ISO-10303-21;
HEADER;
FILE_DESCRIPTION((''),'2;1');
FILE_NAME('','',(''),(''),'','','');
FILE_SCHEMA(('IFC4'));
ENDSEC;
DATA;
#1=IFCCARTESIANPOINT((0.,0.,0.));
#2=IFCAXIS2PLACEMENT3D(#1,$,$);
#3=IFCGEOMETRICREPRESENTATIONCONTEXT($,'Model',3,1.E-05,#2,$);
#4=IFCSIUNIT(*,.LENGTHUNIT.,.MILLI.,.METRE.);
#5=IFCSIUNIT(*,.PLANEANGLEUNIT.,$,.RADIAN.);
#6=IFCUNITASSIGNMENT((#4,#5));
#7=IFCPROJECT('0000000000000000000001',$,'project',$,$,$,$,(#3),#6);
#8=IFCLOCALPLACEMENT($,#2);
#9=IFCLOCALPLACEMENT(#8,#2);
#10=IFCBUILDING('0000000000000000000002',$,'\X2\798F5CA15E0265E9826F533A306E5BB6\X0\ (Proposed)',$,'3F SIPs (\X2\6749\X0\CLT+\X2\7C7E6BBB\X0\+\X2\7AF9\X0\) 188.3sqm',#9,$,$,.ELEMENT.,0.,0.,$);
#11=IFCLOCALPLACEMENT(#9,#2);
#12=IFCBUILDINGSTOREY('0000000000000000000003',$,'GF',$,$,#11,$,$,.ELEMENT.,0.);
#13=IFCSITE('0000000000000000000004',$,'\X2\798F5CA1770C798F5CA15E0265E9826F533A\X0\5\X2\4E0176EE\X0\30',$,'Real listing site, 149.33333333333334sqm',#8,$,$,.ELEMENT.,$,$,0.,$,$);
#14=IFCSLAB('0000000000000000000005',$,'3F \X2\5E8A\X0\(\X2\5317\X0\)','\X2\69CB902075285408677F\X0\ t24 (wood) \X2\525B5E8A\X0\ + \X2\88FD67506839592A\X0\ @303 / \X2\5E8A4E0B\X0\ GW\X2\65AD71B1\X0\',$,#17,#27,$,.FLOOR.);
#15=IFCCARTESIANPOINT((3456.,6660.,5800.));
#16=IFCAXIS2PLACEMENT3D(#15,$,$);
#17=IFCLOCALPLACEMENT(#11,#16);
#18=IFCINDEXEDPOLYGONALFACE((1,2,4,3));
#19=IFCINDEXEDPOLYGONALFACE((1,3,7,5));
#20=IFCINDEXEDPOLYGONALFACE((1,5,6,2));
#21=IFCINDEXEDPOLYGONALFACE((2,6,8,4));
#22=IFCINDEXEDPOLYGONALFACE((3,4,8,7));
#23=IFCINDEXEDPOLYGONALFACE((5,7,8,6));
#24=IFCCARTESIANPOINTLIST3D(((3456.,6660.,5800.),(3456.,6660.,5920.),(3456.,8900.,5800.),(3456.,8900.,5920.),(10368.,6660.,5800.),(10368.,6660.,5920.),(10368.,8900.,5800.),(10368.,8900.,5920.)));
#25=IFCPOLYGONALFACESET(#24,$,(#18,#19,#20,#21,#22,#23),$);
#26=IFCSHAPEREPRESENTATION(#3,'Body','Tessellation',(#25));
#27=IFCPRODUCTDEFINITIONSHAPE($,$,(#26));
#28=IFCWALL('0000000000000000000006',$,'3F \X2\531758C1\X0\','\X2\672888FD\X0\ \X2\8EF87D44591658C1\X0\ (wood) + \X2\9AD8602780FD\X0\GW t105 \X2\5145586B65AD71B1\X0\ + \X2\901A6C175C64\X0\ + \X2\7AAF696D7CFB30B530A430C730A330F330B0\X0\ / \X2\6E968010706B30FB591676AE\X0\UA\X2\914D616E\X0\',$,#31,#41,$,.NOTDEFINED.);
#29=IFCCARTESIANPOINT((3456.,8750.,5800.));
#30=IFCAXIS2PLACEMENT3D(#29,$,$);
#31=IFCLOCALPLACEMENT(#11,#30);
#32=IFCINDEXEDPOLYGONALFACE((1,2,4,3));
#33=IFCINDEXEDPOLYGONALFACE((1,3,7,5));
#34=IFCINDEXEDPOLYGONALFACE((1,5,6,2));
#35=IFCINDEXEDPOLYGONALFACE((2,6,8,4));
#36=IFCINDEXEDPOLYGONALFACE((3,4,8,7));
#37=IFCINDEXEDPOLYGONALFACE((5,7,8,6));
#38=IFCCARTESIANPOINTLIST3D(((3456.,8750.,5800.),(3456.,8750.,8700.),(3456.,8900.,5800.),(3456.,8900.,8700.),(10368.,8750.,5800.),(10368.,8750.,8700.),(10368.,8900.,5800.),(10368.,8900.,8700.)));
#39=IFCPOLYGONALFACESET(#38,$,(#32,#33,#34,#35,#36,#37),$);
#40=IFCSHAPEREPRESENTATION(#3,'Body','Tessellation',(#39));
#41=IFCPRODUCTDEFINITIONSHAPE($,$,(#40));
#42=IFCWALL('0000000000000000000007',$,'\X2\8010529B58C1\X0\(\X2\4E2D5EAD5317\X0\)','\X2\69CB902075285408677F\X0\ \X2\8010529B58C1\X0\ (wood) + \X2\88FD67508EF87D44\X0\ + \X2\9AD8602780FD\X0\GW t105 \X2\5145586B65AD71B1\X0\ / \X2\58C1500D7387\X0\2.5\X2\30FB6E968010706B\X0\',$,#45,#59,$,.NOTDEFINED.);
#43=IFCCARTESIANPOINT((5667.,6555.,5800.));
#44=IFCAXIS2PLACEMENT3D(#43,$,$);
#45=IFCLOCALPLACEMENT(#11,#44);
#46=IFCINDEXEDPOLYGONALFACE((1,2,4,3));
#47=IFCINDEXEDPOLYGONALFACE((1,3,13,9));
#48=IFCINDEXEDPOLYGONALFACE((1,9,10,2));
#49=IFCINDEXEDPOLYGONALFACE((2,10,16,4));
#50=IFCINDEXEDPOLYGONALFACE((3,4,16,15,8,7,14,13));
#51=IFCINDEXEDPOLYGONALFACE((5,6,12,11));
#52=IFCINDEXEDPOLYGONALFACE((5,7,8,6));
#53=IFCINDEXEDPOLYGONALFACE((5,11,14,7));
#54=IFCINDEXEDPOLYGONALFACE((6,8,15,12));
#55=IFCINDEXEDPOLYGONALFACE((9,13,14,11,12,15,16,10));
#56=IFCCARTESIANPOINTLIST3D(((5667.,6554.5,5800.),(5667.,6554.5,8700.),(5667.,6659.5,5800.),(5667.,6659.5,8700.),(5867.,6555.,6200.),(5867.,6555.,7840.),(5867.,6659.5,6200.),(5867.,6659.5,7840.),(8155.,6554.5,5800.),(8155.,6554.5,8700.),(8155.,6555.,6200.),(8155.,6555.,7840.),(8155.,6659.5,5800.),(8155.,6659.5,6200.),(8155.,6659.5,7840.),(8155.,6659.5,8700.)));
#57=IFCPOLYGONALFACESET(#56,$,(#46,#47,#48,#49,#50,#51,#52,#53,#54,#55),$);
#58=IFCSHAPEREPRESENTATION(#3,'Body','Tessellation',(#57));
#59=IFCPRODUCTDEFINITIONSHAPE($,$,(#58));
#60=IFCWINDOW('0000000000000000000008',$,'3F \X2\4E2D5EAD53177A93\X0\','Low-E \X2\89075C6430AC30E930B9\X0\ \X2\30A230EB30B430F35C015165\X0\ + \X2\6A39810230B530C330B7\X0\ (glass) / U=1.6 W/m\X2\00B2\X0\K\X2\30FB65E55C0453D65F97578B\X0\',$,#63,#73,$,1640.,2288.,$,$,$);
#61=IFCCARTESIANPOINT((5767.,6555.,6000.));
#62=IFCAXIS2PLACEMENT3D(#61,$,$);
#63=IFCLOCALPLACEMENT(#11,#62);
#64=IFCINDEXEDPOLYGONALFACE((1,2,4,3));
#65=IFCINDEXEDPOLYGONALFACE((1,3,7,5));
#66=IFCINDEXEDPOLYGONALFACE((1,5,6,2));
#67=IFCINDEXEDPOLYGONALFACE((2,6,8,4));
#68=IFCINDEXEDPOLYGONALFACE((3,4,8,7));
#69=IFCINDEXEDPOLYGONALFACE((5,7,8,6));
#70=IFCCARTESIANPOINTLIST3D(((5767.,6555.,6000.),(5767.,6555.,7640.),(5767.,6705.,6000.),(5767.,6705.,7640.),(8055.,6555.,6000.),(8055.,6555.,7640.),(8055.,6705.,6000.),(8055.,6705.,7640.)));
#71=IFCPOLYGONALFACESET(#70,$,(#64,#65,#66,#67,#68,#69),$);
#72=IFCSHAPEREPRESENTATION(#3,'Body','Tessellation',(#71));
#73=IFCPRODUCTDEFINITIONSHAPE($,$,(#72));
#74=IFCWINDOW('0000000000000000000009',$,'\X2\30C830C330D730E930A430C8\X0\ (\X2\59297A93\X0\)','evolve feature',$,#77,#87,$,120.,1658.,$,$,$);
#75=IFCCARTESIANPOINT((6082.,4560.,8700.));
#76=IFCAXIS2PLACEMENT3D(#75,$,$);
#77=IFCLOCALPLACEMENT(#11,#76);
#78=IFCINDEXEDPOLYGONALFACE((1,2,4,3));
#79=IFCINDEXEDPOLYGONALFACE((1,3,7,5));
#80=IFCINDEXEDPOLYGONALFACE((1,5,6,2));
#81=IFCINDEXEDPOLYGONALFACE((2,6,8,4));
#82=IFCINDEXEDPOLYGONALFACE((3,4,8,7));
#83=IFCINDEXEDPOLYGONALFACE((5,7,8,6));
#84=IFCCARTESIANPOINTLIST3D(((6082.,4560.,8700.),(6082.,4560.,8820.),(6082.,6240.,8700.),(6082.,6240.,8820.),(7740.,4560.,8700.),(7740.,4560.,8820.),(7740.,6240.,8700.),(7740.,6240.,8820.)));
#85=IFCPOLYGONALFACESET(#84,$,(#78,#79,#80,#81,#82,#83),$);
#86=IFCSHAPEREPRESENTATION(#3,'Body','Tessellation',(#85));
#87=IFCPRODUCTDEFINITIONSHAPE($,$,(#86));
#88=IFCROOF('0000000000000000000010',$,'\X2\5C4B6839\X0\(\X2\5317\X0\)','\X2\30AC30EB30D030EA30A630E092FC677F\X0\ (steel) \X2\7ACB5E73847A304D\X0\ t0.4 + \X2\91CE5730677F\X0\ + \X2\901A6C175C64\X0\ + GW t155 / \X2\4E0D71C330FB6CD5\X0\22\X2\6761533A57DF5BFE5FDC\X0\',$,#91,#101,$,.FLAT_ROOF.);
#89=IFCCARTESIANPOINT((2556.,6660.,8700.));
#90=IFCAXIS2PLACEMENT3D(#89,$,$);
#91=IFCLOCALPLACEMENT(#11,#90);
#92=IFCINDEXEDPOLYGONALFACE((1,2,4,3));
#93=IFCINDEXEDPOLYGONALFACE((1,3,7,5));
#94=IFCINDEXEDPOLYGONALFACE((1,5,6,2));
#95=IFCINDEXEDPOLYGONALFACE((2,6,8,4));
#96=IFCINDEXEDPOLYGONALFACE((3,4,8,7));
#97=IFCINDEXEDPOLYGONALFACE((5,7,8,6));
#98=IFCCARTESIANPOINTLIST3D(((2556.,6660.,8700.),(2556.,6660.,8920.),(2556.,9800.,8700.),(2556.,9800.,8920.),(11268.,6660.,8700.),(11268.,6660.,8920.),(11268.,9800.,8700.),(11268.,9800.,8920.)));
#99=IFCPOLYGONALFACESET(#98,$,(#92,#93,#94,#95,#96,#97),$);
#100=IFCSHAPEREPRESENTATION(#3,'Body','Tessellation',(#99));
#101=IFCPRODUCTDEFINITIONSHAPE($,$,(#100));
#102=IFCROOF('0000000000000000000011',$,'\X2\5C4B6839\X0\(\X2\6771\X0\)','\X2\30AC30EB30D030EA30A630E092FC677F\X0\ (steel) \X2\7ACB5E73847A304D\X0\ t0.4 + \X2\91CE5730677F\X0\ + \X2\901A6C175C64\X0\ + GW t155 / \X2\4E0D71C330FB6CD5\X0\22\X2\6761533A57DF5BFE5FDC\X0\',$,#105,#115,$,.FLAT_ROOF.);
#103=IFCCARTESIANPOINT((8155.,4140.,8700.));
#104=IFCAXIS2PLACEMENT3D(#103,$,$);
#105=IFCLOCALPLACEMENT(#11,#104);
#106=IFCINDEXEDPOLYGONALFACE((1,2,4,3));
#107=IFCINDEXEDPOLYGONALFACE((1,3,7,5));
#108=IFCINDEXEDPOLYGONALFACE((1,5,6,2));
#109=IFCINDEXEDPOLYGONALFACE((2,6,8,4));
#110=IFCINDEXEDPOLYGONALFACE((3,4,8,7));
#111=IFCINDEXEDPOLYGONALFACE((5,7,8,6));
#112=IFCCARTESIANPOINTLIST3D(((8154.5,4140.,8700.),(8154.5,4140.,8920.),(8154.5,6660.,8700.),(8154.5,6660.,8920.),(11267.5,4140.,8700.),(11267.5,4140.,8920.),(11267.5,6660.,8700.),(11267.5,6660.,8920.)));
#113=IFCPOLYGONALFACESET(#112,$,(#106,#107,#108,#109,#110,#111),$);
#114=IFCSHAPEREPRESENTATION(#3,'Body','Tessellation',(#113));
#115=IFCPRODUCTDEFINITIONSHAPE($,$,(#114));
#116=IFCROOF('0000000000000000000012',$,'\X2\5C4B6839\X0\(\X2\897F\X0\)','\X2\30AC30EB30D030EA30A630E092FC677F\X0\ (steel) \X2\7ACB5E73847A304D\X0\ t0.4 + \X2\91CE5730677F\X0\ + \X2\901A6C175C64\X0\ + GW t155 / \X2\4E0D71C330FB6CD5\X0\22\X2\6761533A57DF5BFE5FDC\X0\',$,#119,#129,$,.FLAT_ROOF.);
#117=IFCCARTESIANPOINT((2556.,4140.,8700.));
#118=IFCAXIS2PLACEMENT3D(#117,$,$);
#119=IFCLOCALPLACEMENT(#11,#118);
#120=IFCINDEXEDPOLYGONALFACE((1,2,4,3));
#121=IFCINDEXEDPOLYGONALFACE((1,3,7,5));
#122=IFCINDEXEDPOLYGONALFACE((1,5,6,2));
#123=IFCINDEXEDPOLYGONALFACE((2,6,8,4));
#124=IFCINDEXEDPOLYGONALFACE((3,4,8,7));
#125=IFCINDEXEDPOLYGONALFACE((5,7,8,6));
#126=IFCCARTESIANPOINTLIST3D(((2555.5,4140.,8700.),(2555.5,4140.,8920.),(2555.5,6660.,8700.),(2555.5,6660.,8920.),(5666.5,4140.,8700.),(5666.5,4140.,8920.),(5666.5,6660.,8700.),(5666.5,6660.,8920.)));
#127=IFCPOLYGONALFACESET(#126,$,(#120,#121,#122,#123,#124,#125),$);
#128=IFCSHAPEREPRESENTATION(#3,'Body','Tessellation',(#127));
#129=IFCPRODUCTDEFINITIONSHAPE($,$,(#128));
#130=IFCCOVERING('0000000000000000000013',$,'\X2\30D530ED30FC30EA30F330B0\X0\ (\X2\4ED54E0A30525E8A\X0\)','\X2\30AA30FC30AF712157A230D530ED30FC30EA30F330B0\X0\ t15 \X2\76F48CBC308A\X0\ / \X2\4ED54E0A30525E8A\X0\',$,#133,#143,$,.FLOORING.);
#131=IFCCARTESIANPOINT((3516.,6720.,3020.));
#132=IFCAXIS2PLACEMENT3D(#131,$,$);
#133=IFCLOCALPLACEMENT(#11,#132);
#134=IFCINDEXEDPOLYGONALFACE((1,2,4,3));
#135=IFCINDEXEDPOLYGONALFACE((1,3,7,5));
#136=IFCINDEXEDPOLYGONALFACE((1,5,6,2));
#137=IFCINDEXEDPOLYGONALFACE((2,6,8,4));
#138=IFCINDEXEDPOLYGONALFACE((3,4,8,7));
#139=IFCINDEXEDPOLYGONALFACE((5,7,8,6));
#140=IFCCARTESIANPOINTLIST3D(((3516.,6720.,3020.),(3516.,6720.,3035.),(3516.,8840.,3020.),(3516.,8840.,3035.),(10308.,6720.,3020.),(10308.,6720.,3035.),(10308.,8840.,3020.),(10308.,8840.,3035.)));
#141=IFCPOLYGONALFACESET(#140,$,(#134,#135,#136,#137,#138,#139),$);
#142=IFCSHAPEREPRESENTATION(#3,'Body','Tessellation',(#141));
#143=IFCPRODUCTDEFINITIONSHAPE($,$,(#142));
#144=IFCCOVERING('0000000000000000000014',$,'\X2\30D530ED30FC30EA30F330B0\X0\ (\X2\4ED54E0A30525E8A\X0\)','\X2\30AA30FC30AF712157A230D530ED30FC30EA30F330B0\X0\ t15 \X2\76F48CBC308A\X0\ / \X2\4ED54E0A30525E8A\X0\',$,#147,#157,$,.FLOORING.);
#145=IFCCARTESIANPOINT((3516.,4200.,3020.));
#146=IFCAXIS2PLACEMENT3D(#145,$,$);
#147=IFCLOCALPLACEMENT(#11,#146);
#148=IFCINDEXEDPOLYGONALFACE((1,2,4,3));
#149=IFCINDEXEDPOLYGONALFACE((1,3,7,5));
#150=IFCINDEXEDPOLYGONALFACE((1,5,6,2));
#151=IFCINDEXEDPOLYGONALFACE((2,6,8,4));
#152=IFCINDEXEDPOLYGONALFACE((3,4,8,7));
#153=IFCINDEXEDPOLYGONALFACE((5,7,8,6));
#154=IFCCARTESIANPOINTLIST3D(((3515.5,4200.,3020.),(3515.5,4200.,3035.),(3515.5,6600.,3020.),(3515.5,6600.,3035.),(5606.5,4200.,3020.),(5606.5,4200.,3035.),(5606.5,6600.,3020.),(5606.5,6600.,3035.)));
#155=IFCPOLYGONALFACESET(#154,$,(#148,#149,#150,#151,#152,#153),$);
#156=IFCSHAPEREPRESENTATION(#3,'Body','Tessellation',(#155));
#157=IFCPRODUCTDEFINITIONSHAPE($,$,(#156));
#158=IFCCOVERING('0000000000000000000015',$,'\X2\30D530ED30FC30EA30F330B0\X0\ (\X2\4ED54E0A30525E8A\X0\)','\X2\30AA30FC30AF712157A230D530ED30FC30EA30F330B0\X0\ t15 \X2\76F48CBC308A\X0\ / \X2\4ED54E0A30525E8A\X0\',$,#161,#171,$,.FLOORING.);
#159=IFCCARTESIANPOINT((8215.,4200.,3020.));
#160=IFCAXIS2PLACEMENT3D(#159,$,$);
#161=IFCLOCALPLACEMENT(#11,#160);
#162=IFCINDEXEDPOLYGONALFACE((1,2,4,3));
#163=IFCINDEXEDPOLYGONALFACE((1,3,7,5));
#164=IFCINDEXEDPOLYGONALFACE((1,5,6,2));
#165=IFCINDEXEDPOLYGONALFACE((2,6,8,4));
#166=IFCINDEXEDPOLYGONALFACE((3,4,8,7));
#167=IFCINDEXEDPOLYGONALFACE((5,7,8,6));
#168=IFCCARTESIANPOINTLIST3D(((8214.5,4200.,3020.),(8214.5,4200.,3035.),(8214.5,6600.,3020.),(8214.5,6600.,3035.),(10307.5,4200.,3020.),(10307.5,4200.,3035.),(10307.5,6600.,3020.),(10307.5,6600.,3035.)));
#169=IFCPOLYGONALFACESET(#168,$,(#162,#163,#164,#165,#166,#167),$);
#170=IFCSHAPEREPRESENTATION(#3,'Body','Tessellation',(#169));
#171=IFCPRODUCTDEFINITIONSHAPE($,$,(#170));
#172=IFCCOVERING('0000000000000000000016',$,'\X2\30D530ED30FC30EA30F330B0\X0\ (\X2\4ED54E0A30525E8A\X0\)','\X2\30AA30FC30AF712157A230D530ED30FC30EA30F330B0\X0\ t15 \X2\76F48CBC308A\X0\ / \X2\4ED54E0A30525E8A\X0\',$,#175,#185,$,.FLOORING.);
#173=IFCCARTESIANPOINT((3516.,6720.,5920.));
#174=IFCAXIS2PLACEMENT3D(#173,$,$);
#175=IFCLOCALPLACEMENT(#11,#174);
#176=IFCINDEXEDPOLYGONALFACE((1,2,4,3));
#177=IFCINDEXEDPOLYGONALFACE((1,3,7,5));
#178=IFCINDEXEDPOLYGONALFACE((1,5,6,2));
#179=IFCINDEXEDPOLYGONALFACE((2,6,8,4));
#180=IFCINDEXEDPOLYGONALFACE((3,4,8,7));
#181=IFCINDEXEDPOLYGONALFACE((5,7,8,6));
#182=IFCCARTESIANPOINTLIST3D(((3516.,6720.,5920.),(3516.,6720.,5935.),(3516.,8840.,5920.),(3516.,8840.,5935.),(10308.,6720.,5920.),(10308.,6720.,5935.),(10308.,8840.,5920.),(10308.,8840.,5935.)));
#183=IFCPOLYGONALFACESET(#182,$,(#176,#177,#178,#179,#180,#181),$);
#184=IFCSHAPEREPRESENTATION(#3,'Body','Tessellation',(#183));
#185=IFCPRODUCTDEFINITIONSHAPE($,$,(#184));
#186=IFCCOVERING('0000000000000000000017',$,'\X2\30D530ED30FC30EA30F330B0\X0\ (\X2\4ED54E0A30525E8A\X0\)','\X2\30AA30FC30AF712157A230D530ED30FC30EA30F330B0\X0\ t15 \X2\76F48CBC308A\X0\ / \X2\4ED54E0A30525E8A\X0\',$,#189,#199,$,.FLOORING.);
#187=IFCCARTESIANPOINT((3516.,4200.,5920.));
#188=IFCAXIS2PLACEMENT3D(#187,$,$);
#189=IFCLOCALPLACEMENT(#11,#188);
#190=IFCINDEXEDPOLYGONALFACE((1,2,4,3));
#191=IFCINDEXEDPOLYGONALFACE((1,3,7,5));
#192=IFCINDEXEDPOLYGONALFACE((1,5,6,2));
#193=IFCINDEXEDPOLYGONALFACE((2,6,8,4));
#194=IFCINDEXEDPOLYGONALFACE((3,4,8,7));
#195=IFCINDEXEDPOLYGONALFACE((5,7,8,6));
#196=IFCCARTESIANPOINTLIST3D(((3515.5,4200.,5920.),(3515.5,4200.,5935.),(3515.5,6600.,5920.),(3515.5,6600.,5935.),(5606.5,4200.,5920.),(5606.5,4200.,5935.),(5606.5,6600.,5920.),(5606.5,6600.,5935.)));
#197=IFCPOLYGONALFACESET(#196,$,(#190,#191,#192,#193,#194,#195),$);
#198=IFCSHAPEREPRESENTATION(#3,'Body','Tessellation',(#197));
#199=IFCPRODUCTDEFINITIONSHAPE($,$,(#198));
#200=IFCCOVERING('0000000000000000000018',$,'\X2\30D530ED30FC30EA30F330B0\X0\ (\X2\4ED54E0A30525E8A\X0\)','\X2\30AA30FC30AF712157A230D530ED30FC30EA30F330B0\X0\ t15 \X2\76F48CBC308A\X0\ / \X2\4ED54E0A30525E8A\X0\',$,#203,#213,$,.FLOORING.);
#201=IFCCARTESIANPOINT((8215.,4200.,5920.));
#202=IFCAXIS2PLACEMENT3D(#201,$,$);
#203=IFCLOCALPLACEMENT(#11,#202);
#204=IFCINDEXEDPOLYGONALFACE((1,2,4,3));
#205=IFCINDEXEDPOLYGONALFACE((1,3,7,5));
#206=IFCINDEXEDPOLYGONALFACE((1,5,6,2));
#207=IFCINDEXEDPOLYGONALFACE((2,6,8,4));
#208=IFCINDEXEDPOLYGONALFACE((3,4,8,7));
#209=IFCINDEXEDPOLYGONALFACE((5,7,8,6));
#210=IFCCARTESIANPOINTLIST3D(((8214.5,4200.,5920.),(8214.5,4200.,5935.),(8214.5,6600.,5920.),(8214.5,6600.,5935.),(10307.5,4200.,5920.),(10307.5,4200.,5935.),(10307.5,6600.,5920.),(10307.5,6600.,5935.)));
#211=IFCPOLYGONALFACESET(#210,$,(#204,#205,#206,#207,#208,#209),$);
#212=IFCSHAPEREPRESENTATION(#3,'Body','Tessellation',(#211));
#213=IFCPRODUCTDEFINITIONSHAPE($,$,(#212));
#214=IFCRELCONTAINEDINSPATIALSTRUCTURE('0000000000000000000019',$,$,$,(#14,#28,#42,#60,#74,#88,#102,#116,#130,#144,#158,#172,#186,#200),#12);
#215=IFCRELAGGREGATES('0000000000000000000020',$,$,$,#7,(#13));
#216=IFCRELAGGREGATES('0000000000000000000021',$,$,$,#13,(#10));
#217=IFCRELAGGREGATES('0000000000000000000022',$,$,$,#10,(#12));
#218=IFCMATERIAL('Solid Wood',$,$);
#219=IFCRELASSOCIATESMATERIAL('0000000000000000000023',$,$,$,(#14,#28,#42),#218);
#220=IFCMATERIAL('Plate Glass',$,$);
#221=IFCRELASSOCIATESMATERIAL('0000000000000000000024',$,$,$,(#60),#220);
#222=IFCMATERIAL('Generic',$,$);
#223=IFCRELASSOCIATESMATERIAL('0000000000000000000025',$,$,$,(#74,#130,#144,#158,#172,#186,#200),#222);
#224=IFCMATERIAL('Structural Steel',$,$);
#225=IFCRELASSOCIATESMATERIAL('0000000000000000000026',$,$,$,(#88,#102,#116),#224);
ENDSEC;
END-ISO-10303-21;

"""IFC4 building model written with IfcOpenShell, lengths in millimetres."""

from ifc_helpers import new_model, si_unit, frame, frame_2d, origin, place, context, project, spatial, rectangle, extrude, material, element, fill, save


model = new_model("IFC4")

# Units and contexts
model_context = context("Model", 3, precision=1e-05, world=origin())
ifc_project = project(units=[si_unit("LENGTHUNIT", "METRE", prefix="MILLI"), si_unit("PLANEANGLEUNIT", "RADIAN")], contexts=[model_context])

# Site, building, storey
site_placement = place(None, origin())
site = spatial("IfcSite", under=ifc_project, at=site_placement, Name="福岡県福岡市早良区5丁目30", ObjectType="Real listing site, 149.33333333333334sqm", CompositionType="ELEMENT", RefElevation=0.0)
building_placement = place(site_placement, origin())
building = spatial("IfcBuilding", under=site, at=building_placement, Name="福岡市早良区の家 (Proposed)", ObjectType="3F SIPs (杉CLT+籾殻+竹) 188.3sqm", CompositionType="ELEMENT", ElevationOfRefHeight=0.0, ElevationOfTerrain=0.0)
storey_placement = place(building_placement, origin())
storey = spatial("IfcBuildingStorey", under=building, at=storey_placement, Name="GF", CompositionType="ELEMENT", Elevation=0.0)

# Slab
ifc_material_1 = material(Name="Solid Wood")
slab_placement = place(storey_placement, frame((3456.0, 6660.0, 5800.0)))
element("IfcSlab", 1, at=slab_placement, inside=storey, material=ifc_material_1, Name="3F 床(北)", Description="構造用合板 t24 (wood) 剛床 + 製材根太 @303 / 床下 GW断熱", PredefinedType="FLOOR", context=model_context, shape_type="SweptSolid", body=[
    extrude(rectangle(XDim=6912.0, YDim=2240.0, at=frame_2d((3456.0, 1120.0))), frame((3456.0, 6660.0, 5800.0)), (0.0, 0.0, 1.0), 120.0),
])

# Wall
wall_1_placement = place(storey_placement, frame((3456.0, 8750.0, 5800.0)))
element("IfcWall", 2, at=wall_1_placement, inside=storey, material=ifc_material_1, Name="3F 北壁", Description="木製 軸組外壁 (wood) + 高性能GW t105 充填断熱 + 通気層 + 窯業系サイディング / 準耐火・外皮UA配慮", PredefinedType="NOTDEFINED", context=model_context, shape_type="SweptSolid", body=[
    extrude(rectangle(XDim=6912.0, YDim=150.0, at=frame_2d((3456.0, 75.0))), frame((3456.0, 8750.0, 5800.0)), (0.0, 0.0, 1.0), 2900.0),
])

# Wall, opening, window
wall_2_placement = place(storey_placement, frame((5667.0, 6555.0, 5800.0)))
wall_2 = element("IfcWall", 3, at=wall_2_placement, inside=storey, material=ifc_material_1, Name="耐力壁(中庭北)", Description="構造用合板 耐力壁 (wood) + 製材軸組 + 高性能GW t105 充填断熱 / 壁倍率2.5・準耐火", PredefinedType="NOTDEFINED", context=model_context, shape_type="SweptSolid", body=[
    extrude(rectangle(XDim=2488.0, YDim=105.0, at=frame_2d((1244.0, 52.0))), frame((5667.0, 6555.0, 5800.0)), (0.0, 0.0, 1.0), 2900.0),
])
opening_placement = place(storey_placement, frame((5767.0, 6555.0, 6000.0)))
opening = element("IfcOpeningElement", 4, at=opening_placement, cuts=wall_2, PredefinedType="NOTDEFINED", context=model_context, shape_type="SweptSolid", body=[
    extrude(rectangle(XDim=2288.0, YDim=150.0, at=frame_2d((1144.0, 75.0))), frame((5767.0, 6555.0, 6000.0)), (0.0, 0.0, 1.0), 1640.0),
])
ifc_material_2 = material(Name="Plate Glass")
window_1_placement = place(storey_placement, frame((5767.0, 6555.0, 6000.0)))
window_1 = element("IfcWindow", 5, at=window_1_placement, inside=storey, material=ifc_material_2, Name="3F 中庭北窓", Description="Low-E 複層ガラス アルゴン封入 + 樹脂サッシ (glass) / U=1.6 W/m²K・日射取得型", OverallHeight=1640.0, OverallWidth=2288.0, context=model_context, shape_type="SweptSolid", body=[
    extrude(rectangle(XDim=2288.0, YDim=150.0, at=frame_2d((1144.0, 75.0))), frame((5767.0, 6555.0, 6000.0)), (0.0, 0.0, 1.0), 1640.0),
])
fill(opening, window_1)

# Window
ifc_material_3 = material(Name="Generic")
window_2_placement = place(storey_placement, frame((6082.0, 4560.0, 8700.0)))
element("IfcWindow", 6, at=window_2_placement, inside=storey, material=ifc_material_3, Name="トップライト (天窓)", Description="evolve feature", OverallHeight=120.0, OverallWidth=1658.0, context=model_context, shape_type="SweptSolid", body=[
    extrude(rectangle(XDim=1658.0, YDim=1680.0, at=frame_2d((829.0, 840.0))), frame((6082.0, 4560.0, 8700.0)), (0.0, 0.0, 1.0), 120.0),
])

# Roofs
ifc_material_4 = material(Name="Structural Steel")
roof_1_placement = place(storey_placement, frame((2556.0, 6660.0, 8700.0)))
element("IfcRoof", 7, at=roof_1_placement, inside=storey, material=ifc_material_4, Name="屋根(北)", Description="ガルバリウム鋼板 (steel) 立平葺き t0.4 + 野地板 + 通気層 + GW t155 / 不燃・法22条区域対応", PredefinedType="FLAT_ROOF", context=model_context, shape_type="SweptSolid", body=[
    extrude(rectangle(XDim=8712.0, YDim=3140.0, at=frame_2d((4356.0, 1570.0))), frame((2556.0, 6660.0, 8700.0)), (0.0, 0.0, 1.0), 220.0),
])
roof_2_placement = place(storey_placement, frame((8155.0, 4140.0, 8700.0)))
element("IfcRoof", 8, at=roof_2_placement, inside=storey, material=ifc_material_4, Name="屋根(東)", Description="ガルバリウム鋼板 (steel) 立平葺き t0.4 + 野地板 + 通気層 + GW t155 / 不燃・法22条区域対応", PredefinedType="FLAT_ROOF", context=model_context, shape_type="SweptSolid", body=[
    extrude(rectangle(XDim=3113.0, YDim=2520.0, at=frame_2d((1556.0, 1260.0))), frame((8155.0, 4140.0, 8700.0)), (0.0, 0.0, 1.0), 220.0),
])
roof_3_placement = place(storey_placement, frame((2556.0, 4140.0, 8700.0)))
element("IfcRoof", 9, at=roof_3_placement, inside=storey, material=ifc_material_4, Name="屋根(西)", Description="ガルバリウム鋼板 (steel) 立平葺き t0.4 + 野地板 + 通気層 + GW t155 / 不燃・法22条区域対応", PredefinedType="FLAT_ROOF", context=model_context, shape_type="SweptSolid", body=[
    extrude(rectangle(XDim=3111.0, YDim=2520.0, at=frame_2d((1555.0, 1260.0))), frame((2556.0, 4140.0, 8700.0)), (0.0, 0.0, 1.0), 220.0),
])

# Coverings
covering_1_placement = place(storey_placement, frame((3516.0, 6720.0, 3020.0)))
element("IfcCovering", 10, at=covering_1_placement, inside=storey, material=ifc_material_3, Name="フローリング (仕上げ床)", Description="オーク無垢フローリング t15 直貼り / 仕上げ床", PredefinedType="FLOORING", context=model_context, shape_type="SweptSolid", body=[
    extrude(rectangle(XDim=6792.0, YDim=2120.0, at=frame_2d((3396.0, 1060.0))), frame((3516.0, 6720.0, 3020.0)), (0.0, 0.0, 1.0), 15.0),
])
covering_2_placement = place(storey_placement, frame((3516.0, 4200.0, 3020.0)))
element("IfcCovering", 11, at=covering_2_placement, inside=storey, material=ifc_material_3, Name="フローリング (仕上げ床)", Description="オーク無垢フローリング t15 直貼り / 仕上げ床", PredefinedType="FLOORING", context=model_context, shape_type="SweptSolid", body=[
    extrude(rectangle(XDim=2091.0, YDim=2400.0, at=frame_2d((1045.0, 1200.0))), frame((3516.0, 4200.0, 3020.0)), (0.0, 0.0, 1.0), 15.0),
])
covering_3_placement = place(storey_placement, frame((8215.0, 4200.0, 3020.0)))
element("IfcCovering", 12, at=covering_3_placement, inside=storey, material=ifc_material_3, Name="フローリング (仕上げ床)", Description="オーク無垢フローリング t15 直貼り / 仕上げ床", PredefinedType="FLOORING", context=model_context, shape_type="SweptSolid", body=[
    extrude(rectangle(XDim=2093.0, YDim=2400.0, at=frame_2d((1046.0, 1200.0))), frame((8215.0, 4200.0, 3020.0)), (0.0, 0.0, 1.0), 15.0),
])
covering_4_placement = place(storey_placement, frame((3516.0, 6720.0, 5920.0)))
element("IfcCovering", 13, at=covering_4_placement, inside=storey, material=ifc_material_3, Name="フローリング (仕上げ床)", Description="オーク無垢フローリング t15 直貼り / 仕上げ床", PredefinedType="FLOORING", context=model_context, shape_type="SweptSolid", body=[
    extrude(rectangle(XDim=6792.0, YDim=2120.0, at=frame_2d((3396.0, 1060.0))), frame((3516.0, 6720.0, 5920.0)), (0.0, 0.0, 1.0), 15.0),
])
covering_5_placement = place(storey_placement, frame((3516.0, 4200.0, 5920.0)))
element("IfcCovering", 14, at=covering_5_placement, inside=storey, material=ifc_material_3, Name="フローリング (仕上げ床)", Description="オーク無垢フローリング t15 直貼り / 仕上げ床", PredefinedType="FLOORING", context=model_context, shape_type="SweptSolid", body=[
    extrude(rectangle(XDim=2091.0, YDim=2400.0, at=frame_2d((1045.0, 1200.0))), frame((3516.0, 4200.0, 5920.0)), (0.0, 0.0, 1.0), 15.0),
])
covering_6_placement = place(storey_placement, frame((8215.0, 4200.0, 5920.0)))
element("IfcCovering", 15, at=covering_6_placement, inside=storey, material=ifc_material_3, Name="フローリング (仕上げ床)", Description="オーク無垢フローリング t15 直貼り / 仕上げ床", PredefinedType="FLOORING", context=model_context, shape_type="SweptSolid", body=[
    extrude(rectangle(XDim=2093.0, YDim=2400.0, at=frame_2d((1046.0, 1200.0))), frame((8215.0, 4200.0, 5920.0)), (0.0, 0.0, 1.0), 15.0),
])

save(model, "model.ifc")
